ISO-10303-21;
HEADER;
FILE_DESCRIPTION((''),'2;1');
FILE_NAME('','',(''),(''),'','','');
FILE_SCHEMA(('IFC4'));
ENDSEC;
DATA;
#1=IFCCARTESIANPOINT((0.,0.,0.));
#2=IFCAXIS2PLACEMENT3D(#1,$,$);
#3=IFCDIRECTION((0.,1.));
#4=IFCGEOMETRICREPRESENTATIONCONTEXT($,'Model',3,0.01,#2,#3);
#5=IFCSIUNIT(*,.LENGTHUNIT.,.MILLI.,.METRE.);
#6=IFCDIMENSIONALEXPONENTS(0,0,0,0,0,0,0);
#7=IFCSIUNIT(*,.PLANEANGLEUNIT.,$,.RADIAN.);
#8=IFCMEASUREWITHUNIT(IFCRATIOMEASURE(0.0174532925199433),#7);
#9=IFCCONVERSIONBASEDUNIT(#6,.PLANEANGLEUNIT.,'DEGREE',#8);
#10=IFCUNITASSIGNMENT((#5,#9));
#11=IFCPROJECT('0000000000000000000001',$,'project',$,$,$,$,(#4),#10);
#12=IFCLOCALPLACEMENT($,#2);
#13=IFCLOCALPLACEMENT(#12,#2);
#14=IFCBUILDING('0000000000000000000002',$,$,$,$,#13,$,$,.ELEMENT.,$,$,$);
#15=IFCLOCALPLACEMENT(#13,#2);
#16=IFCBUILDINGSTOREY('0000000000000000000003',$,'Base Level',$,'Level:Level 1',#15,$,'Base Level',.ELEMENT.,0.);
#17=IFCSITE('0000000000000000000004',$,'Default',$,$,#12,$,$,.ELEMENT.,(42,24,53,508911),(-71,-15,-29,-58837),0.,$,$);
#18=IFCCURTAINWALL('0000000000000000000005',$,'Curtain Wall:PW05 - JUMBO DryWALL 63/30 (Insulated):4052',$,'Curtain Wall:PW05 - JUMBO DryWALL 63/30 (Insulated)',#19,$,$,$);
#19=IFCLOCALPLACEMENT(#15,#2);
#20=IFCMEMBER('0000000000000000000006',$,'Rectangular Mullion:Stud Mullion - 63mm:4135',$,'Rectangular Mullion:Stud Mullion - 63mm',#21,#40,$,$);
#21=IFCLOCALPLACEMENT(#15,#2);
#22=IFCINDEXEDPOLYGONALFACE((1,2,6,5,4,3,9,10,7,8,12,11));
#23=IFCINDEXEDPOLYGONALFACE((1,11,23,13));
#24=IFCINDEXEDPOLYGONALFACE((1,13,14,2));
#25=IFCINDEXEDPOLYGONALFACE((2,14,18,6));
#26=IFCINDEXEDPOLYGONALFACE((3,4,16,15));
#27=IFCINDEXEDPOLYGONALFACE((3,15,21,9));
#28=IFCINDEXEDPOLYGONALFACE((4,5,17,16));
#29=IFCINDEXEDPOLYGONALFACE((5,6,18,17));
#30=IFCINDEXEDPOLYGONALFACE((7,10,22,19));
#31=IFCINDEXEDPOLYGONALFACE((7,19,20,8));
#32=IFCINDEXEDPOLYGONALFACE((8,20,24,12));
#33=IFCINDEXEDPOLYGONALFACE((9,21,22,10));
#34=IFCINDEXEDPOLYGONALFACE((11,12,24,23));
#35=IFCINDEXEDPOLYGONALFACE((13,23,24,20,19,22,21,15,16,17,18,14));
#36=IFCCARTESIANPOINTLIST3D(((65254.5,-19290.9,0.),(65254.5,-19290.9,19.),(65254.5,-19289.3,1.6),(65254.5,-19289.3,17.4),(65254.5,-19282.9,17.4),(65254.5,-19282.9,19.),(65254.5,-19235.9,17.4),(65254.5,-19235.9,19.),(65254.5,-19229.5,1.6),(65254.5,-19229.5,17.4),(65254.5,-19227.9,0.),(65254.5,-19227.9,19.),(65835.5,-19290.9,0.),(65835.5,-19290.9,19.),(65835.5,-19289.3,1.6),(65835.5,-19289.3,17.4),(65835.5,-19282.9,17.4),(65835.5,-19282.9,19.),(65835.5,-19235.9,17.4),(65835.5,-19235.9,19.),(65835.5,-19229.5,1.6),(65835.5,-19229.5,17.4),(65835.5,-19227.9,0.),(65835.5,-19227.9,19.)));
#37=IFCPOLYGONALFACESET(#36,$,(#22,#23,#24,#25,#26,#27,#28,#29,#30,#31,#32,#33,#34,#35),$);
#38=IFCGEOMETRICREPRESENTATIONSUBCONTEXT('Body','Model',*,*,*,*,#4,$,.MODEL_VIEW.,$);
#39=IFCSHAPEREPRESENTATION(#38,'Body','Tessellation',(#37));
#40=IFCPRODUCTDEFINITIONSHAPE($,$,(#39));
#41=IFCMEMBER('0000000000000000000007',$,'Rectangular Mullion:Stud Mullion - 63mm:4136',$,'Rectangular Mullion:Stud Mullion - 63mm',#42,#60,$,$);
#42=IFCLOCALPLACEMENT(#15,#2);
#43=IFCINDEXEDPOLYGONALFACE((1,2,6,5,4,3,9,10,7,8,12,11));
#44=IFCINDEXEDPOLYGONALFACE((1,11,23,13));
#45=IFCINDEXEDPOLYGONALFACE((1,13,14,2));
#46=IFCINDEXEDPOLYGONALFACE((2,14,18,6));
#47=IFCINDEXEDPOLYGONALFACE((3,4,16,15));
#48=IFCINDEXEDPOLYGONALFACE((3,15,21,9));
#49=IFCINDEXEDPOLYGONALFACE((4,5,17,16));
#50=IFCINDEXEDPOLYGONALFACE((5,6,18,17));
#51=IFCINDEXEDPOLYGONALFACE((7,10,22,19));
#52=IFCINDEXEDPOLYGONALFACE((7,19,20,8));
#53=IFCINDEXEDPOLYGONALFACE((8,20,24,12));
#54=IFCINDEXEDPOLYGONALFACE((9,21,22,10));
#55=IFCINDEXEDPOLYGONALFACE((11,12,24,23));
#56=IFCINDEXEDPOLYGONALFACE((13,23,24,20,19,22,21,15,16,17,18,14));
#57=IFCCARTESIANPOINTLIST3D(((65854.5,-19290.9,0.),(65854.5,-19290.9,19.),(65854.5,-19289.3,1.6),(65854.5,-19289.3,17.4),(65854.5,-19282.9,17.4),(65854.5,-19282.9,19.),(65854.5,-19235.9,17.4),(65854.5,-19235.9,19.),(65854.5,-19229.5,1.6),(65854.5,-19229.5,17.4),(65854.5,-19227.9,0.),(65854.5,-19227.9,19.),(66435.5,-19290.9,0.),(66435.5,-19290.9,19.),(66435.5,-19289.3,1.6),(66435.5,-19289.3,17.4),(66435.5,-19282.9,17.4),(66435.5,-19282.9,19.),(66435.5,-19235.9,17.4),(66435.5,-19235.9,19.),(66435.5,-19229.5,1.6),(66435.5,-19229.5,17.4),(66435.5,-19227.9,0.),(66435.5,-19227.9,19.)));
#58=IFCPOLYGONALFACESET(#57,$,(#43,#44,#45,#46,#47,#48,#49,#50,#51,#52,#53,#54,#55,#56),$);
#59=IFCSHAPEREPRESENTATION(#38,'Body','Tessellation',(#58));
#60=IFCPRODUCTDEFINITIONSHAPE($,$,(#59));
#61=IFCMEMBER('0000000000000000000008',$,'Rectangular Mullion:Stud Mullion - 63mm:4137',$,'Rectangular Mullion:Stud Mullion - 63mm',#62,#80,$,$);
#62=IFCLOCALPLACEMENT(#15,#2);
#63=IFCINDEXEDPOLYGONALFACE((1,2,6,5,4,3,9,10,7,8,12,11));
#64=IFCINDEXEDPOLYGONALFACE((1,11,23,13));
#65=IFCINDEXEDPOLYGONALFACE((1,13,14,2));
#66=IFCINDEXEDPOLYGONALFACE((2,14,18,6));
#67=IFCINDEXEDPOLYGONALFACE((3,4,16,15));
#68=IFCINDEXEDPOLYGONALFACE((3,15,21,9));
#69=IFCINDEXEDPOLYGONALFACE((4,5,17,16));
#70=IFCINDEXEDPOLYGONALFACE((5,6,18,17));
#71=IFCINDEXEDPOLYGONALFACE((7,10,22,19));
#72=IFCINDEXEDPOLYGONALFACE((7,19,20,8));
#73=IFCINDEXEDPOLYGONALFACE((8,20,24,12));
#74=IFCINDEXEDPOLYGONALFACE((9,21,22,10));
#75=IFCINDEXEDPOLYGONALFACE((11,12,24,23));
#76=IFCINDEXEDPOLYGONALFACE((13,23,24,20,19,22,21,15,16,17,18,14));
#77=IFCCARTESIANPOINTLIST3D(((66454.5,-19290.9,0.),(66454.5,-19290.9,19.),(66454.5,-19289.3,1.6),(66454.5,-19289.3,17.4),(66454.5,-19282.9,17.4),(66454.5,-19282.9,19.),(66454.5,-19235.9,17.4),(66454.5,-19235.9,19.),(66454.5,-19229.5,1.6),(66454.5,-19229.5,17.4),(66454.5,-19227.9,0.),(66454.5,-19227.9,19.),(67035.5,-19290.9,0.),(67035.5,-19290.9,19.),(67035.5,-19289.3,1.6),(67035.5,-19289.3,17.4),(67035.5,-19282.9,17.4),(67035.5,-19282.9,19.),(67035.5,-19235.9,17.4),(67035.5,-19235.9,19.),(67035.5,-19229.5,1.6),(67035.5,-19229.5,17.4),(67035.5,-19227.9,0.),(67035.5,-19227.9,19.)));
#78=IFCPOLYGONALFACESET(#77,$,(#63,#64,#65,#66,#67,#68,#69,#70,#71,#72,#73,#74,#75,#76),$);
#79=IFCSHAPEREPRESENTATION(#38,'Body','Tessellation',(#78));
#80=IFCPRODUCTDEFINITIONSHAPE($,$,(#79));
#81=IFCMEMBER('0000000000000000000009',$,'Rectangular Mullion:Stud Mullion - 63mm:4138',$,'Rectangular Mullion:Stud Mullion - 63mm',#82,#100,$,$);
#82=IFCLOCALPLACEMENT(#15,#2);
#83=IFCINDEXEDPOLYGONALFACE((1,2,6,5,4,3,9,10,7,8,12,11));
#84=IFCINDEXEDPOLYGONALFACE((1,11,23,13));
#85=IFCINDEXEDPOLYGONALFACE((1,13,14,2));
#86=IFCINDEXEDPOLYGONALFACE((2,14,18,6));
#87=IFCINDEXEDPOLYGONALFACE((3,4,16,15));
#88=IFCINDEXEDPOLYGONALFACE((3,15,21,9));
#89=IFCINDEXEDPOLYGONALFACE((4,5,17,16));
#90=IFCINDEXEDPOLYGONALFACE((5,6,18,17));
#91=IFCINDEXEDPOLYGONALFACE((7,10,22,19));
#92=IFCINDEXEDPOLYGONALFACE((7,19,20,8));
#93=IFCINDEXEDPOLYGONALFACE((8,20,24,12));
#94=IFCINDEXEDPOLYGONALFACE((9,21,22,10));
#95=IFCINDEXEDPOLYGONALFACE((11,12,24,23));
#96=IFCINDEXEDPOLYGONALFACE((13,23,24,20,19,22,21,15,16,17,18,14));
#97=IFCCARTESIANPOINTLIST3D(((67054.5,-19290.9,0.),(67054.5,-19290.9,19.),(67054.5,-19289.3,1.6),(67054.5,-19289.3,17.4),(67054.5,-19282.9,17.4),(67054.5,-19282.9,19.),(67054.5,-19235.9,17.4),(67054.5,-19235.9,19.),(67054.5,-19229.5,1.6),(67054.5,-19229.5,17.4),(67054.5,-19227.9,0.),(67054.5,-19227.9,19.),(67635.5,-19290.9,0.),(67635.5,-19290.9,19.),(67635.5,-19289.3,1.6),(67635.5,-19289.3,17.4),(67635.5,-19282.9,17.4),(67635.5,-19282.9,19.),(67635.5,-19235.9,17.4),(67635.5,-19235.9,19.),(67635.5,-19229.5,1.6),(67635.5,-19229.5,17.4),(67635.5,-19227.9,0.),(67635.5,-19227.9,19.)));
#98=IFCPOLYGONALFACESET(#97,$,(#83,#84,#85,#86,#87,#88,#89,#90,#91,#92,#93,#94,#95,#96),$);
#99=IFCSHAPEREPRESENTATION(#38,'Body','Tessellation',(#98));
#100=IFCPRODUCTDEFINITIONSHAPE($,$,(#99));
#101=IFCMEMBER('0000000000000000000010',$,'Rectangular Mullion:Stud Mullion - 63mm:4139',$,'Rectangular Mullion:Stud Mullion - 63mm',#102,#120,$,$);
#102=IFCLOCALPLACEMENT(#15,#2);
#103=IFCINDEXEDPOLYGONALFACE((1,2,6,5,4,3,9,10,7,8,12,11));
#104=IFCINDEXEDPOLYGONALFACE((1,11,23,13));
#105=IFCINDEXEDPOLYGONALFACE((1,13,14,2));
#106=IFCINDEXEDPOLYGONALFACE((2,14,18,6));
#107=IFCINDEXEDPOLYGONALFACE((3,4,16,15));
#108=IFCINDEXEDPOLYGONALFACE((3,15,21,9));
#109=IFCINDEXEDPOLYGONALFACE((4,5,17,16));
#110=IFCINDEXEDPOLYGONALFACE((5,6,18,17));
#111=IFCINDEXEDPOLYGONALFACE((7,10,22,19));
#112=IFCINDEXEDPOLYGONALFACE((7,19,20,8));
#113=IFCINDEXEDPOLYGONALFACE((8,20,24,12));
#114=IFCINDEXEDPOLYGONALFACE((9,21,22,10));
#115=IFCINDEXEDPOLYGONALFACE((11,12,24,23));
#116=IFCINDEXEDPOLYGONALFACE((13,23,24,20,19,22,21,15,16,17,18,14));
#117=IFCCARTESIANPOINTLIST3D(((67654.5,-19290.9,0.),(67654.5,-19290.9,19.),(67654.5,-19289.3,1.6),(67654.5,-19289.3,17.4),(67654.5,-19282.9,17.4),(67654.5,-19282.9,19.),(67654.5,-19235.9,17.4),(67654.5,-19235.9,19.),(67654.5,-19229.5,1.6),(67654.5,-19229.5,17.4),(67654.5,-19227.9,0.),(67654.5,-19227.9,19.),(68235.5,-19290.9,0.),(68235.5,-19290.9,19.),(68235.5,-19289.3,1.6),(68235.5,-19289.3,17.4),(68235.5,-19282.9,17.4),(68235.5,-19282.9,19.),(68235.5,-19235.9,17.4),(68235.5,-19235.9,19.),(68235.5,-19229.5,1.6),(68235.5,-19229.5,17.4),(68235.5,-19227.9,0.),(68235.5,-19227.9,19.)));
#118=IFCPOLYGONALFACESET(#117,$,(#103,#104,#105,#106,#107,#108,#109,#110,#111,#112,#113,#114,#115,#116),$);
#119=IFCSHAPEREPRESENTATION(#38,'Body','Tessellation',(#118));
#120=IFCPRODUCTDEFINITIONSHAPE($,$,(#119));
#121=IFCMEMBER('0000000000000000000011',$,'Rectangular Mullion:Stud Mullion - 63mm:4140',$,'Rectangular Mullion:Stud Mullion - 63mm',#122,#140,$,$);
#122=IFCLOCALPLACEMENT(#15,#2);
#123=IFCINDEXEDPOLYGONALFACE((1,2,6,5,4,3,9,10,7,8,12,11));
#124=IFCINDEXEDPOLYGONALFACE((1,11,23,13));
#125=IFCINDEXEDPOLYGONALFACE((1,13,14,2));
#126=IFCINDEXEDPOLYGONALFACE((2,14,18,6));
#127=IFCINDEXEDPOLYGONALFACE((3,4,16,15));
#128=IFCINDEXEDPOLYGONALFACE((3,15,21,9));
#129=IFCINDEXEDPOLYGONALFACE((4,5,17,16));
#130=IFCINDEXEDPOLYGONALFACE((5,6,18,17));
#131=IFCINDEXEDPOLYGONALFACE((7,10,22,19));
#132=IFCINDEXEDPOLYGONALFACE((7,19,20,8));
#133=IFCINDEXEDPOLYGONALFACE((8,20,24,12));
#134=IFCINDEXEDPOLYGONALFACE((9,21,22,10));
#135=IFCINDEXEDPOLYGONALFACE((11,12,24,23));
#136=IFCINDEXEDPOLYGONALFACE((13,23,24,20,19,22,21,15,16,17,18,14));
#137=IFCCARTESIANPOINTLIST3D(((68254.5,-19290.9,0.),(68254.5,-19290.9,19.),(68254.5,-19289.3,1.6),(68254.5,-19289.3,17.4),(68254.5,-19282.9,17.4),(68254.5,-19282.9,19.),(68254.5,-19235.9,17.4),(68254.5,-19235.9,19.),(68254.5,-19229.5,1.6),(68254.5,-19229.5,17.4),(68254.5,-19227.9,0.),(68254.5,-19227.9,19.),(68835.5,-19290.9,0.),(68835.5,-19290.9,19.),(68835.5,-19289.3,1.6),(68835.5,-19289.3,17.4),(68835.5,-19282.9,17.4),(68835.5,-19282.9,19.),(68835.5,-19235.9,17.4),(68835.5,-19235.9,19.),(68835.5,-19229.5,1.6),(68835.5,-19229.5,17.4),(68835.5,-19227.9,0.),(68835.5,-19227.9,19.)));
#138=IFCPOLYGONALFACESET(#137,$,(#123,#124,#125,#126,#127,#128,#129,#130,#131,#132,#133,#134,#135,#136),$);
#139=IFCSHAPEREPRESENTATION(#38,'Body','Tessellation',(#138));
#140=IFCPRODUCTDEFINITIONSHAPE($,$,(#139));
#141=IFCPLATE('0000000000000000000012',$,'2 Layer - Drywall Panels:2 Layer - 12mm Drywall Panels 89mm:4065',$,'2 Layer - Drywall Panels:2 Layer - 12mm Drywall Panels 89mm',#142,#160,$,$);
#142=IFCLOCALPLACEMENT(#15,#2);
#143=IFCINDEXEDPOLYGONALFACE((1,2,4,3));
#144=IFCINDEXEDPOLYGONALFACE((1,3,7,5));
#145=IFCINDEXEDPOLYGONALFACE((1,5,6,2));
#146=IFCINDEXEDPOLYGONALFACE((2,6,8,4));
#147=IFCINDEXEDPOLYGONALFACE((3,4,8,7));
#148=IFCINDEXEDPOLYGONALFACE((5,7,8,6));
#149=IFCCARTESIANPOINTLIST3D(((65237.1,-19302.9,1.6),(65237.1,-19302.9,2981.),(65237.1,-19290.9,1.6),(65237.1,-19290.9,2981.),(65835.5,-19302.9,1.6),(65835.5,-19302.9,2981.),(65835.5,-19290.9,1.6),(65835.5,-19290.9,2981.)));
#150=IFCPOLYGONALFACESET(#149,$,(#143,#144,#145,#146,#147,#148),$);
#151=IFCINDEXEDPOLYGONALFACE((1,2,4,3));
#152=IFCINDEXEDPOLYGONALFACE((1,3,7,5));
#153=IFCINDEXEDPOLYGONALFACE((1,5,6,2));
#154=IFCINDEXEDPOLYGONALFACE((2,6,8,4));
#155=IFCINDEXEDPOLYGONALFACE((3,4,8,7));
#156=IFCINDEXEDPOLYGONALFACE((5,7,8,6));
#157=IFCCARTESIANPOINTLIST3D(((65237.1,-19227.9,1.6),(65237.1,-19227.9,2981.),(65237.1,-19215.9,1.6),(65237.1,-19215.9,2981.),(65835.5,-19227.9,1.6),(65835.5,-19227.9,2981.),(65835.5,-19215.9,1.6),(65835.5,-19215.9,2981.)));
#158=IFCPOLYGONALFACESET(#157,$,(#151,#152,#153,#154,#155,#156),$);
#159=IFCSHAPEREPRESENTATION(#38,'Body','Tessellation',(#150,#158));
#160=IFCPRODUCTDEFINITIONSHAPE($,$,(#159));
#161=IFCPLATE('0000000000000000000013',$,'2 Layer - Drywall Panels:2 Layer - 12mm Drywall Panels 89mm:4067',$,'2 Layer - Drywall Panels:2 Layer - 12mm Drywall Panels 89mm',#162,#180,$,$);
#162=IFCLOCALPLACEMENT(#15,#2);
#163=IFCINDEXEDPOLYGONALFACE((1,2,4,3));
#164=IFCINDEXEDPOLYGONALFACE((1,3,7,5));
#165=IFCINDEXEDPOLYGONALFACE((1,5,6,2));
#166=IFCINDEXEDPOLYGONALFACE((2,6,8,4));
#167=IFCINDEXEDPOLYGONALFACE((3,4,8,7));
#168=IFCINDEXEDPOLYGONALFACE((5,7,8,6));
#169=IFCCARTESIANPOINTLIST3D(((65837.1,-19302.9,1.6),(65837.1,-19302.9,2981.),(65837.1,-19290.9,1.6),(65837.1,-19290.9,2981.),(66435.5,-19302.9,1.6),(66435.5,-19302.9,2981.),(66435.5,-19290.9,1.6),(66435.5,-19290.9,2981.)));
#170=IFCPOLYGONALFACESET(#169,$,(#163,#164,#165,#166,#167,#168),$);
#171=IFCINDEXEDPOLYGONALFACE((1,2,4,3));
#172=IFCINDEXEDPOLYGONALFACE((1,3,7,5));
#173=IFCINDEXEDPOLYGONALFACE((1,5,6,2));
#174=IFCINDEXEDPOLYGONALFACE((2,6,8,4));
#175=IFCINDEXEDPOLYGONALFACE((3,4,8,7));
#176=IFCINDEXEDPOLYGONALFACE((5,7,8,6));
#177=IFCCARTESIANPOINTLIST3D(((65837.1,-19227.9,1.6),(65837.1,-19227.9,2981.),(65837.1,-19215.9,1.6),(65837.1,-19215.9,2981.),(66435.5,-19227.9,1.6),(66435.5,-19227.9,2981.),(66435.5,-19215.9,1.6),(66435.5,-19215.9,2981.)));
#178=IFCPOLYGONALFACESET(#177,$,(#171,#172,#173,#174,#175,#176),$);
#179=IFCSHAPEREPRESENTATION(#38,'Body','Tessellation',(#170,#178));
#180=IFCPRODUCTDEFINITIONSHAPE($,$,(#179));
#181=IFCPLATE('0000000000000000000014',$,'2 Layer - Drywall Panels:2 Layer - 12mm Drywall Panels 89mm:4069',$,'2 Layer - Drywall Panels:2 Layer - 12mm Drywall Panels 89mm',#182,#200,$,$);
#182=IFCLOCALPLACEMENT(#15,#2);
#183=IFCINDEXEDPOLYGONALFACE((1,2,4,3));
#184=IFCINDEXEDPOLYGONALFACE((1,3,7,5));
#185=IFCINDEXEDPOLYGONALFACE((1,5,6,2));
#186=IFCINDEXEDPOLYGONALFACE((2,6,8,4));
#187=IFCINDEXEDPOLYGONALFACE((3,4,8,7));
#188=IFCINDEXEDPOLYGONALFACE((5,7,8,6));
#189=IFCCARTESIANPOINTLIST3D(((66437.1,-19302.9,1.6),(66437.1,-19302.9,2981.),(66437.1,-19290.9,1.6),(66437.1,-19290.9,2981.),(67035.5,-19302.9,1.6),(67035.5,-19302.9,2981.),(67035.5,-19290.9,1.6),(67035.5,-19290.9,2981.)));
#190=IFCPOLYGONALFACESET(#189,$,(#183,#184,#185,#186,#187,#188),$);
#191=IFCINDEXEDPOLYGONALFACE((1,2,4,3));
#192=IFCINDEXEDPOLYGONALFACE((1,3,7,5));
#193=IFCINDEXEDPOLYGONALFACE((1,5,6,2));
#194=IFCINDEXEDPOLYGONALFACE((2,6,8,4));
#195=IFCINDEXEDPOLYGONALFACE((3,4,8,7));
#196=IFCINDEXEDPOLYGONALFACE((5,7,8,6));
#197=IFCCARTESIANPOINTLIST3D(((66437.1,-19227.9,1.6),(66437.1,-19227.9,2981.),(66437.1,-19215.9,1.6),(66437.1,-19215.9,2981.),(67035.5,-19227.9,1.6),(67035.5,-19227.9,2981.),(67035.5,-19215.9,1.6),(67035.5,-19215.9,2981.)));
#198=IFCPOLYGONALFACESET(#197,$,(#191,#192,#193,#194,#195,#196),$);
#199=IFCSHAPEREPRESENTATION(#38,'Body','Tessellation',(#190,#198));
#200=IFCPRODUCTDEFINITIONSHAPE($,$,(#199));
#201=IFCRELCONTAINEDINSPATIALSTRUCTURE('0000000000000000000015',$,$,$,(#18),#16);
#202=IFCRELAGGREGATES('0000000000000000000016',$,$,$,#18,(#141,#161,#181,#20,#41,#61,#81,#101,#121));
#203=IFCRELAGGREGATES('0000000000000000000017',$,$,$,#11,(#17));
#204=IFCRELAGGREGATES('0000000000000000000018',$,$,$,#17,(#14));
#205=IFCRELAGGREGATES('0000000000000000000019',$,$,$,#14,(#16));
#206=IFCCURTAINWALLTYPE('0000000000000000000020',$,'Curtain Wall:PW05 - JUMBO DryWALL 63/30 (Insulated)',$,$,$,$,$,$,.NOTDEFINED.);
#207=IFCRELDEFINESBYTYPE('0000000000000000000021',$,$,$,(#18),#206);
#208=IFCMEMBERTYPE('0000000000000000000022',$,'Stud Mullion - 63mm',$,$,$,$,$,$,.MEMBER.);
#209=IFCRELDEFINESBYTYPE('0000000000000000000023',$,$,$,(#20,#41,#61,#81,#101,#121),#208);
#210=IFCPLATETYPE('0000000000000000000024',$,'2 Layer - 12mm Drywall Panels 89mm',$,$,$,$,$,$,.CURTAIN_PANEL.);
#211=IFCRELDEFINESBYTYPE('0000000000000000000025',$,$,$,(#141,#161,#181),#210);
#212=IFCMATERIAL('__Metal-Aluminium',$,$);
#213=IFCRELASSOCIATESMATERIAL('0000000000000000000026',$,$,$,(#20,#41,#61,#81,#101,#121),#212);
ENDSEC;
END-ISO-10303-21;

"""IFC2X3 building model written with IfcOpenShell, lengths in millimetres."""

from ifc_helpers import new_model, entity, si_unit, converted_unit, direction, frame, frame_2d, origin, place, context, subcontext, project, spatial, polyline, rectangle, outline, extrude, source, transform, mapped, material, type_object, type_shapes, element, aggregate, save


model = new_model("IFC2X3")

# Units and contexts
model_context = context("Model", 3, precision=0.01, world=origin(), true_north=direction((0.0, 1.0)))
body_context = subcontext(model_context, "Body", "Model", "MODEL_VIEW")
ifc_project = project(units=[si_unit("LENGTHUNIT", "METRE", prefix="MILLI"), converted_unit("PLANEANGLEUNIT", "DEGREE", entity("IfcRatioMeasure", 0.0174532925199433), si_unit("PLANEANGLEUNIT", "RADIAN"), dimensions=[0, 0, 0, 0, 0, 0, 0])], contexts=[model_context])

# Site, building, storey
site_placement = place(None, origin())
site = spatial("IfcSite", under=ifc_project, at=site_placement, Name="Default", CompositionType="ELEMENT", RefLatitude=(42, 24, 53, 508911), RefLongitude=(-71, -15, -29, -58837), RefElevation=0.0)
building_placement = place(site_placement, origin())
building = spatial("IfcBuilding", under=site, at=building_placement, CompositionType="ELEMENT")
storey_placement = place(building_placement, origin())
storey = spatial("IfcBuildingStorey", under=building, at=storey_placement, Name="Base Level", ObjectType="Level:Level 1", LongName="Base Level", CompositionType="ELEMENT", Elevation=0.0)

# Curtain wall, members, plates
curtain_wall_type = type_object("IfcCurtainWallType", Name="Curtain Wall:PW05 - JUMBO DryWALL 63/30 (Insulated)", PredefinedType="NOTDEFINED")
curtain_wall_placement = place(building_placement, origin())
curtain_wall = element("IfcCurtainWall", 1, at=curtain_wall_placement, inside=storey, type_object=curtain_wall_type, Name="Curtain Wall:PW05 - JUMBO DryWALL 63/30 (Insulated):4052", ObjectType="Curtain Wall:PW05 - JUMBO DryWALL 63/30 (Insulated)")
ifc_material = material(Name="__Metal-Aluminium")
member_type_1 = type_object("IfcMemberType", Name="Stud Mullion - 63mm", PredefinedType="MEMBER")
shared_shape_1 = source(origin(), body_context, "Body", "SweptSolid", [
    extrude(outline(polyline([(23.5, -6.6), (31.5, -6.6), (31.5, 12.4), (-31.5, 12.4), (-31.5, -6.6), (-23.5, -6.6), (-23.5, -5.0), (-29.9, -5.0), (-29.9, 10.8), (29.9, 10.8), (29.9, -5.0), (23.5, -5.0), (23.5, -6.6)])), frame((-12.4, 0.0, -581.0), z_axis=(0.0, 0.0, 1.0), x_axis=(0.0, -1.0, 0.0)), (0.0, 0.0, 1.0), 581.0),
])
type_shapes(member_type_1, [shared_shape_1])
member_1_placement = place(building_placement, frame((65254.5, -19259.4, 0.0), z_axis=(-1.0, 0.0, 0.0), x_axis=(0.0, 0.0, -1.0)))
member_1 = element("IfcMember", 2, at=member_1_placement, type_object=member_type_1, material=ifc_material, Name="Rectangular Mullion:Stud Mullion - 63mm:4135", ObjectType="Rectangular Mullion:Stud Mullion - 63mm", context=body_context, shape_type="MappedRepresentation", body=[
    mapped(shared_shape_1, transform((0.0, 0.0, 0.0), scale=1.0)),
])
member_2_placement = place(building_placement, frame((65854.5, -19259.4, 0.0), z_axis=(-1.0, 0.0, 0.0), x_axis=(0.0, 0.0, -1.0)))
member_2 = element("IfcMember", 3, at=member_2_placement, type_object=member_type_1, material=ifc_material, Name="Rectangular Mullion:Stud Mullion - 63mm:4136", ObjectType="Rectangular Mullion:Stud Mullion - 63mm", context=body_context, shape_type="MappedRepresentation", body=[
    mapped(shared_shape_1, transform((0.0, 0.0, 0.0), scale=1.0)),
])
member_3_placement = place(building_placement, frame((66454.5, -19259.4, 0.0), z_axis=(-1.0, 0.0, 0.0), x_axis=(0.0, 0.0, -1.0)))
member_3 = element("IfcMember", 4, at=member_3_placement, type_object=member_type_1, material=ifc_material, Name="Rectangular Mullion:Stud Mullion - 63mm:4137", ObjectType="Rectangular Mullion:Stud Mullion - 63mm", context=body_context, shape_type="MappedRepresentation", body=[
    mapped(shared_shape_1, transform((0.0, 0.0, 0.0), scale=1.0)),
])
member_4_placement = place(building_placement, frame((67054.5, -19259.4, 0.0), z_axis=(-1.0, 0.0, 0.0), x_axis=(0.0, 0.0, -1.0)))
member_4 = element("IfcMember", 5, at=member_4_placement, type_object=member_type_1, material=ifc_material, Name="Rectangular Mullion:Stud Mullion - 63mm:4138", ObjectType="Rectangular Mullion:Stud Mullion - 63mm", context=body_context, shape_type="MappedRepresentation", body=[
    mapped(shared_shape_1, transform((0.0, 0.0, 0.0), scale=1.0)),
])
member_5_placement = place(building_placement, frame((67654.5, -19259.4, 0.0), z_axis=(-1.0, 0.0, 0.0), x_axis=(0.0, 0.0, -1.0)))
member_5 = element("IfcMember", 6, at=member_5_placement, type_object=member_type_1, material=ifc_material, Name="Rectangular Mullion:Stud Mullion - 63mm:4139", ObjectType="Rectangular Mullion:Stud Mullion - 63mm", context=body_context, shape_type="MappedRepresentation", body=[
    mapped(shared_shape_1, transform((0.0, 0.0, 0.0), scale=1.0)),
])
member_6_placement = place(building_placement, frame((68254.5, -19259.4, 0.0), z_axis=(-1.0, 0.0, 0.0), x_axis=(0.0, 0.0, -1.0)))
member_6 = element("IfcMember", 7, at=member_6_placement, type_object=member_type_1, material=ifc_material, Name="Rectangular Mullion:Stud Mullion - 63mm:4140", ObjectType="Rectangular Mullion:Stud Mullion - 63mm", context=body_context, shape_type="MappedRepresentation", body=[
    mapped(shared_shape_1, transform((0.0, 0.0, 0.0), scale=1.0)),
])
plate_type = type_object("IfcPlateType", Name="2 Layer - 12mm Drywall Panels 89mm", PredefinedType="CURTAIN_PANEL")
shared_shape_2 = source(origin(), body_context, "Body", "SweptSolid", [
    extrude(rectangle(XDim=598.4, YDim=12.0, at=frame_2d((0.0, 0.0), x_axis=(1.0, 0.0))), frame((0.0, -37.5, 0.0), z_axis=(0.0, 0.0, 1.0), x_axis=(-1.0, 0.0, 0.0)), (0.0, 0.0, 1.0), 2979.4),
    extrude(rectangle(XDim=12.0, YDim=598.4, at=frame_2d((0.0, 0.0), x_axis=(1.0, 0.0))), frame((0.0, 37.5, 0.0), z_axis=(0.0, 0.0, 1.0), x_axis=(0.0, 1.0, 0.0)), (0.0, 0.0, 1.0), 2979.4),
])
type_shapes(plate_type, [shared_shape_2])
plate_1_placement = place(curtain_wall_placement, frame((65536.3, -19259.4, 1.6)))
plate_1 = element("IfcPlate", 8, at=plate_1_placement, type_object=plate_type, Name="2 Layer - Drywall Panels:2 Layer - 12mm Drywall Panels 89mm:4065", ObjectType="2 Layer - Drywall Panels:2 Layer - 12mm Drywall Panels 89mm", context=body_context, shape_type="MappedRepresentation", body=[
    mapped(shared_shape_2, transform((0.0, 0.0, 0.0), scale=1.0)),
])
plate_2_placement = place(curtain_wall_placement, frame((66136.3, -19259.4, 1.6)))
plate_2 = element("IfcPlate", 9, at=plate_2_placement, type_object=plate_type, Name="2 Layer - Drywall Panels:2 Layer - 12mm Drywall Panels 89mm:4067", ObjectType="2 Layer - Drywall Panels:2 Layer - 12mm Drywall Panels 89mm", context=body_context, shape_type="MappedRepresentation", body=[
    mapped(shared_shape_2, transform((0.0, 0.0, 0.0), scale=1.0)),
])
plate_3_placement = place(curtain_wall_placement, frame((66736.3, -19259.4, 1.6)))
plate_3 = element("IfcPlate", 10, at=plate_3_placement, type_object=plate_type, Name="2 Layer - Drywall Panels:2 Layer - 12mm Drywall Panels 89mm:4069", ObjectType="2 Layer - Drywall Panels:2 Layer - 12mm Drywall Panels 89mm", context=body_context, shape_type="MappedRepresentation", body=[
    mapped(shared_shape_2, transform((0.0, 0.0, 0.0), scale=1.0)),
])
aggregate(curtain_wall, [plate_1, plate_2, plate_3, member_1, member_2, member_3, member_4, member_5, member_6])

save(model, "model.ifc")
